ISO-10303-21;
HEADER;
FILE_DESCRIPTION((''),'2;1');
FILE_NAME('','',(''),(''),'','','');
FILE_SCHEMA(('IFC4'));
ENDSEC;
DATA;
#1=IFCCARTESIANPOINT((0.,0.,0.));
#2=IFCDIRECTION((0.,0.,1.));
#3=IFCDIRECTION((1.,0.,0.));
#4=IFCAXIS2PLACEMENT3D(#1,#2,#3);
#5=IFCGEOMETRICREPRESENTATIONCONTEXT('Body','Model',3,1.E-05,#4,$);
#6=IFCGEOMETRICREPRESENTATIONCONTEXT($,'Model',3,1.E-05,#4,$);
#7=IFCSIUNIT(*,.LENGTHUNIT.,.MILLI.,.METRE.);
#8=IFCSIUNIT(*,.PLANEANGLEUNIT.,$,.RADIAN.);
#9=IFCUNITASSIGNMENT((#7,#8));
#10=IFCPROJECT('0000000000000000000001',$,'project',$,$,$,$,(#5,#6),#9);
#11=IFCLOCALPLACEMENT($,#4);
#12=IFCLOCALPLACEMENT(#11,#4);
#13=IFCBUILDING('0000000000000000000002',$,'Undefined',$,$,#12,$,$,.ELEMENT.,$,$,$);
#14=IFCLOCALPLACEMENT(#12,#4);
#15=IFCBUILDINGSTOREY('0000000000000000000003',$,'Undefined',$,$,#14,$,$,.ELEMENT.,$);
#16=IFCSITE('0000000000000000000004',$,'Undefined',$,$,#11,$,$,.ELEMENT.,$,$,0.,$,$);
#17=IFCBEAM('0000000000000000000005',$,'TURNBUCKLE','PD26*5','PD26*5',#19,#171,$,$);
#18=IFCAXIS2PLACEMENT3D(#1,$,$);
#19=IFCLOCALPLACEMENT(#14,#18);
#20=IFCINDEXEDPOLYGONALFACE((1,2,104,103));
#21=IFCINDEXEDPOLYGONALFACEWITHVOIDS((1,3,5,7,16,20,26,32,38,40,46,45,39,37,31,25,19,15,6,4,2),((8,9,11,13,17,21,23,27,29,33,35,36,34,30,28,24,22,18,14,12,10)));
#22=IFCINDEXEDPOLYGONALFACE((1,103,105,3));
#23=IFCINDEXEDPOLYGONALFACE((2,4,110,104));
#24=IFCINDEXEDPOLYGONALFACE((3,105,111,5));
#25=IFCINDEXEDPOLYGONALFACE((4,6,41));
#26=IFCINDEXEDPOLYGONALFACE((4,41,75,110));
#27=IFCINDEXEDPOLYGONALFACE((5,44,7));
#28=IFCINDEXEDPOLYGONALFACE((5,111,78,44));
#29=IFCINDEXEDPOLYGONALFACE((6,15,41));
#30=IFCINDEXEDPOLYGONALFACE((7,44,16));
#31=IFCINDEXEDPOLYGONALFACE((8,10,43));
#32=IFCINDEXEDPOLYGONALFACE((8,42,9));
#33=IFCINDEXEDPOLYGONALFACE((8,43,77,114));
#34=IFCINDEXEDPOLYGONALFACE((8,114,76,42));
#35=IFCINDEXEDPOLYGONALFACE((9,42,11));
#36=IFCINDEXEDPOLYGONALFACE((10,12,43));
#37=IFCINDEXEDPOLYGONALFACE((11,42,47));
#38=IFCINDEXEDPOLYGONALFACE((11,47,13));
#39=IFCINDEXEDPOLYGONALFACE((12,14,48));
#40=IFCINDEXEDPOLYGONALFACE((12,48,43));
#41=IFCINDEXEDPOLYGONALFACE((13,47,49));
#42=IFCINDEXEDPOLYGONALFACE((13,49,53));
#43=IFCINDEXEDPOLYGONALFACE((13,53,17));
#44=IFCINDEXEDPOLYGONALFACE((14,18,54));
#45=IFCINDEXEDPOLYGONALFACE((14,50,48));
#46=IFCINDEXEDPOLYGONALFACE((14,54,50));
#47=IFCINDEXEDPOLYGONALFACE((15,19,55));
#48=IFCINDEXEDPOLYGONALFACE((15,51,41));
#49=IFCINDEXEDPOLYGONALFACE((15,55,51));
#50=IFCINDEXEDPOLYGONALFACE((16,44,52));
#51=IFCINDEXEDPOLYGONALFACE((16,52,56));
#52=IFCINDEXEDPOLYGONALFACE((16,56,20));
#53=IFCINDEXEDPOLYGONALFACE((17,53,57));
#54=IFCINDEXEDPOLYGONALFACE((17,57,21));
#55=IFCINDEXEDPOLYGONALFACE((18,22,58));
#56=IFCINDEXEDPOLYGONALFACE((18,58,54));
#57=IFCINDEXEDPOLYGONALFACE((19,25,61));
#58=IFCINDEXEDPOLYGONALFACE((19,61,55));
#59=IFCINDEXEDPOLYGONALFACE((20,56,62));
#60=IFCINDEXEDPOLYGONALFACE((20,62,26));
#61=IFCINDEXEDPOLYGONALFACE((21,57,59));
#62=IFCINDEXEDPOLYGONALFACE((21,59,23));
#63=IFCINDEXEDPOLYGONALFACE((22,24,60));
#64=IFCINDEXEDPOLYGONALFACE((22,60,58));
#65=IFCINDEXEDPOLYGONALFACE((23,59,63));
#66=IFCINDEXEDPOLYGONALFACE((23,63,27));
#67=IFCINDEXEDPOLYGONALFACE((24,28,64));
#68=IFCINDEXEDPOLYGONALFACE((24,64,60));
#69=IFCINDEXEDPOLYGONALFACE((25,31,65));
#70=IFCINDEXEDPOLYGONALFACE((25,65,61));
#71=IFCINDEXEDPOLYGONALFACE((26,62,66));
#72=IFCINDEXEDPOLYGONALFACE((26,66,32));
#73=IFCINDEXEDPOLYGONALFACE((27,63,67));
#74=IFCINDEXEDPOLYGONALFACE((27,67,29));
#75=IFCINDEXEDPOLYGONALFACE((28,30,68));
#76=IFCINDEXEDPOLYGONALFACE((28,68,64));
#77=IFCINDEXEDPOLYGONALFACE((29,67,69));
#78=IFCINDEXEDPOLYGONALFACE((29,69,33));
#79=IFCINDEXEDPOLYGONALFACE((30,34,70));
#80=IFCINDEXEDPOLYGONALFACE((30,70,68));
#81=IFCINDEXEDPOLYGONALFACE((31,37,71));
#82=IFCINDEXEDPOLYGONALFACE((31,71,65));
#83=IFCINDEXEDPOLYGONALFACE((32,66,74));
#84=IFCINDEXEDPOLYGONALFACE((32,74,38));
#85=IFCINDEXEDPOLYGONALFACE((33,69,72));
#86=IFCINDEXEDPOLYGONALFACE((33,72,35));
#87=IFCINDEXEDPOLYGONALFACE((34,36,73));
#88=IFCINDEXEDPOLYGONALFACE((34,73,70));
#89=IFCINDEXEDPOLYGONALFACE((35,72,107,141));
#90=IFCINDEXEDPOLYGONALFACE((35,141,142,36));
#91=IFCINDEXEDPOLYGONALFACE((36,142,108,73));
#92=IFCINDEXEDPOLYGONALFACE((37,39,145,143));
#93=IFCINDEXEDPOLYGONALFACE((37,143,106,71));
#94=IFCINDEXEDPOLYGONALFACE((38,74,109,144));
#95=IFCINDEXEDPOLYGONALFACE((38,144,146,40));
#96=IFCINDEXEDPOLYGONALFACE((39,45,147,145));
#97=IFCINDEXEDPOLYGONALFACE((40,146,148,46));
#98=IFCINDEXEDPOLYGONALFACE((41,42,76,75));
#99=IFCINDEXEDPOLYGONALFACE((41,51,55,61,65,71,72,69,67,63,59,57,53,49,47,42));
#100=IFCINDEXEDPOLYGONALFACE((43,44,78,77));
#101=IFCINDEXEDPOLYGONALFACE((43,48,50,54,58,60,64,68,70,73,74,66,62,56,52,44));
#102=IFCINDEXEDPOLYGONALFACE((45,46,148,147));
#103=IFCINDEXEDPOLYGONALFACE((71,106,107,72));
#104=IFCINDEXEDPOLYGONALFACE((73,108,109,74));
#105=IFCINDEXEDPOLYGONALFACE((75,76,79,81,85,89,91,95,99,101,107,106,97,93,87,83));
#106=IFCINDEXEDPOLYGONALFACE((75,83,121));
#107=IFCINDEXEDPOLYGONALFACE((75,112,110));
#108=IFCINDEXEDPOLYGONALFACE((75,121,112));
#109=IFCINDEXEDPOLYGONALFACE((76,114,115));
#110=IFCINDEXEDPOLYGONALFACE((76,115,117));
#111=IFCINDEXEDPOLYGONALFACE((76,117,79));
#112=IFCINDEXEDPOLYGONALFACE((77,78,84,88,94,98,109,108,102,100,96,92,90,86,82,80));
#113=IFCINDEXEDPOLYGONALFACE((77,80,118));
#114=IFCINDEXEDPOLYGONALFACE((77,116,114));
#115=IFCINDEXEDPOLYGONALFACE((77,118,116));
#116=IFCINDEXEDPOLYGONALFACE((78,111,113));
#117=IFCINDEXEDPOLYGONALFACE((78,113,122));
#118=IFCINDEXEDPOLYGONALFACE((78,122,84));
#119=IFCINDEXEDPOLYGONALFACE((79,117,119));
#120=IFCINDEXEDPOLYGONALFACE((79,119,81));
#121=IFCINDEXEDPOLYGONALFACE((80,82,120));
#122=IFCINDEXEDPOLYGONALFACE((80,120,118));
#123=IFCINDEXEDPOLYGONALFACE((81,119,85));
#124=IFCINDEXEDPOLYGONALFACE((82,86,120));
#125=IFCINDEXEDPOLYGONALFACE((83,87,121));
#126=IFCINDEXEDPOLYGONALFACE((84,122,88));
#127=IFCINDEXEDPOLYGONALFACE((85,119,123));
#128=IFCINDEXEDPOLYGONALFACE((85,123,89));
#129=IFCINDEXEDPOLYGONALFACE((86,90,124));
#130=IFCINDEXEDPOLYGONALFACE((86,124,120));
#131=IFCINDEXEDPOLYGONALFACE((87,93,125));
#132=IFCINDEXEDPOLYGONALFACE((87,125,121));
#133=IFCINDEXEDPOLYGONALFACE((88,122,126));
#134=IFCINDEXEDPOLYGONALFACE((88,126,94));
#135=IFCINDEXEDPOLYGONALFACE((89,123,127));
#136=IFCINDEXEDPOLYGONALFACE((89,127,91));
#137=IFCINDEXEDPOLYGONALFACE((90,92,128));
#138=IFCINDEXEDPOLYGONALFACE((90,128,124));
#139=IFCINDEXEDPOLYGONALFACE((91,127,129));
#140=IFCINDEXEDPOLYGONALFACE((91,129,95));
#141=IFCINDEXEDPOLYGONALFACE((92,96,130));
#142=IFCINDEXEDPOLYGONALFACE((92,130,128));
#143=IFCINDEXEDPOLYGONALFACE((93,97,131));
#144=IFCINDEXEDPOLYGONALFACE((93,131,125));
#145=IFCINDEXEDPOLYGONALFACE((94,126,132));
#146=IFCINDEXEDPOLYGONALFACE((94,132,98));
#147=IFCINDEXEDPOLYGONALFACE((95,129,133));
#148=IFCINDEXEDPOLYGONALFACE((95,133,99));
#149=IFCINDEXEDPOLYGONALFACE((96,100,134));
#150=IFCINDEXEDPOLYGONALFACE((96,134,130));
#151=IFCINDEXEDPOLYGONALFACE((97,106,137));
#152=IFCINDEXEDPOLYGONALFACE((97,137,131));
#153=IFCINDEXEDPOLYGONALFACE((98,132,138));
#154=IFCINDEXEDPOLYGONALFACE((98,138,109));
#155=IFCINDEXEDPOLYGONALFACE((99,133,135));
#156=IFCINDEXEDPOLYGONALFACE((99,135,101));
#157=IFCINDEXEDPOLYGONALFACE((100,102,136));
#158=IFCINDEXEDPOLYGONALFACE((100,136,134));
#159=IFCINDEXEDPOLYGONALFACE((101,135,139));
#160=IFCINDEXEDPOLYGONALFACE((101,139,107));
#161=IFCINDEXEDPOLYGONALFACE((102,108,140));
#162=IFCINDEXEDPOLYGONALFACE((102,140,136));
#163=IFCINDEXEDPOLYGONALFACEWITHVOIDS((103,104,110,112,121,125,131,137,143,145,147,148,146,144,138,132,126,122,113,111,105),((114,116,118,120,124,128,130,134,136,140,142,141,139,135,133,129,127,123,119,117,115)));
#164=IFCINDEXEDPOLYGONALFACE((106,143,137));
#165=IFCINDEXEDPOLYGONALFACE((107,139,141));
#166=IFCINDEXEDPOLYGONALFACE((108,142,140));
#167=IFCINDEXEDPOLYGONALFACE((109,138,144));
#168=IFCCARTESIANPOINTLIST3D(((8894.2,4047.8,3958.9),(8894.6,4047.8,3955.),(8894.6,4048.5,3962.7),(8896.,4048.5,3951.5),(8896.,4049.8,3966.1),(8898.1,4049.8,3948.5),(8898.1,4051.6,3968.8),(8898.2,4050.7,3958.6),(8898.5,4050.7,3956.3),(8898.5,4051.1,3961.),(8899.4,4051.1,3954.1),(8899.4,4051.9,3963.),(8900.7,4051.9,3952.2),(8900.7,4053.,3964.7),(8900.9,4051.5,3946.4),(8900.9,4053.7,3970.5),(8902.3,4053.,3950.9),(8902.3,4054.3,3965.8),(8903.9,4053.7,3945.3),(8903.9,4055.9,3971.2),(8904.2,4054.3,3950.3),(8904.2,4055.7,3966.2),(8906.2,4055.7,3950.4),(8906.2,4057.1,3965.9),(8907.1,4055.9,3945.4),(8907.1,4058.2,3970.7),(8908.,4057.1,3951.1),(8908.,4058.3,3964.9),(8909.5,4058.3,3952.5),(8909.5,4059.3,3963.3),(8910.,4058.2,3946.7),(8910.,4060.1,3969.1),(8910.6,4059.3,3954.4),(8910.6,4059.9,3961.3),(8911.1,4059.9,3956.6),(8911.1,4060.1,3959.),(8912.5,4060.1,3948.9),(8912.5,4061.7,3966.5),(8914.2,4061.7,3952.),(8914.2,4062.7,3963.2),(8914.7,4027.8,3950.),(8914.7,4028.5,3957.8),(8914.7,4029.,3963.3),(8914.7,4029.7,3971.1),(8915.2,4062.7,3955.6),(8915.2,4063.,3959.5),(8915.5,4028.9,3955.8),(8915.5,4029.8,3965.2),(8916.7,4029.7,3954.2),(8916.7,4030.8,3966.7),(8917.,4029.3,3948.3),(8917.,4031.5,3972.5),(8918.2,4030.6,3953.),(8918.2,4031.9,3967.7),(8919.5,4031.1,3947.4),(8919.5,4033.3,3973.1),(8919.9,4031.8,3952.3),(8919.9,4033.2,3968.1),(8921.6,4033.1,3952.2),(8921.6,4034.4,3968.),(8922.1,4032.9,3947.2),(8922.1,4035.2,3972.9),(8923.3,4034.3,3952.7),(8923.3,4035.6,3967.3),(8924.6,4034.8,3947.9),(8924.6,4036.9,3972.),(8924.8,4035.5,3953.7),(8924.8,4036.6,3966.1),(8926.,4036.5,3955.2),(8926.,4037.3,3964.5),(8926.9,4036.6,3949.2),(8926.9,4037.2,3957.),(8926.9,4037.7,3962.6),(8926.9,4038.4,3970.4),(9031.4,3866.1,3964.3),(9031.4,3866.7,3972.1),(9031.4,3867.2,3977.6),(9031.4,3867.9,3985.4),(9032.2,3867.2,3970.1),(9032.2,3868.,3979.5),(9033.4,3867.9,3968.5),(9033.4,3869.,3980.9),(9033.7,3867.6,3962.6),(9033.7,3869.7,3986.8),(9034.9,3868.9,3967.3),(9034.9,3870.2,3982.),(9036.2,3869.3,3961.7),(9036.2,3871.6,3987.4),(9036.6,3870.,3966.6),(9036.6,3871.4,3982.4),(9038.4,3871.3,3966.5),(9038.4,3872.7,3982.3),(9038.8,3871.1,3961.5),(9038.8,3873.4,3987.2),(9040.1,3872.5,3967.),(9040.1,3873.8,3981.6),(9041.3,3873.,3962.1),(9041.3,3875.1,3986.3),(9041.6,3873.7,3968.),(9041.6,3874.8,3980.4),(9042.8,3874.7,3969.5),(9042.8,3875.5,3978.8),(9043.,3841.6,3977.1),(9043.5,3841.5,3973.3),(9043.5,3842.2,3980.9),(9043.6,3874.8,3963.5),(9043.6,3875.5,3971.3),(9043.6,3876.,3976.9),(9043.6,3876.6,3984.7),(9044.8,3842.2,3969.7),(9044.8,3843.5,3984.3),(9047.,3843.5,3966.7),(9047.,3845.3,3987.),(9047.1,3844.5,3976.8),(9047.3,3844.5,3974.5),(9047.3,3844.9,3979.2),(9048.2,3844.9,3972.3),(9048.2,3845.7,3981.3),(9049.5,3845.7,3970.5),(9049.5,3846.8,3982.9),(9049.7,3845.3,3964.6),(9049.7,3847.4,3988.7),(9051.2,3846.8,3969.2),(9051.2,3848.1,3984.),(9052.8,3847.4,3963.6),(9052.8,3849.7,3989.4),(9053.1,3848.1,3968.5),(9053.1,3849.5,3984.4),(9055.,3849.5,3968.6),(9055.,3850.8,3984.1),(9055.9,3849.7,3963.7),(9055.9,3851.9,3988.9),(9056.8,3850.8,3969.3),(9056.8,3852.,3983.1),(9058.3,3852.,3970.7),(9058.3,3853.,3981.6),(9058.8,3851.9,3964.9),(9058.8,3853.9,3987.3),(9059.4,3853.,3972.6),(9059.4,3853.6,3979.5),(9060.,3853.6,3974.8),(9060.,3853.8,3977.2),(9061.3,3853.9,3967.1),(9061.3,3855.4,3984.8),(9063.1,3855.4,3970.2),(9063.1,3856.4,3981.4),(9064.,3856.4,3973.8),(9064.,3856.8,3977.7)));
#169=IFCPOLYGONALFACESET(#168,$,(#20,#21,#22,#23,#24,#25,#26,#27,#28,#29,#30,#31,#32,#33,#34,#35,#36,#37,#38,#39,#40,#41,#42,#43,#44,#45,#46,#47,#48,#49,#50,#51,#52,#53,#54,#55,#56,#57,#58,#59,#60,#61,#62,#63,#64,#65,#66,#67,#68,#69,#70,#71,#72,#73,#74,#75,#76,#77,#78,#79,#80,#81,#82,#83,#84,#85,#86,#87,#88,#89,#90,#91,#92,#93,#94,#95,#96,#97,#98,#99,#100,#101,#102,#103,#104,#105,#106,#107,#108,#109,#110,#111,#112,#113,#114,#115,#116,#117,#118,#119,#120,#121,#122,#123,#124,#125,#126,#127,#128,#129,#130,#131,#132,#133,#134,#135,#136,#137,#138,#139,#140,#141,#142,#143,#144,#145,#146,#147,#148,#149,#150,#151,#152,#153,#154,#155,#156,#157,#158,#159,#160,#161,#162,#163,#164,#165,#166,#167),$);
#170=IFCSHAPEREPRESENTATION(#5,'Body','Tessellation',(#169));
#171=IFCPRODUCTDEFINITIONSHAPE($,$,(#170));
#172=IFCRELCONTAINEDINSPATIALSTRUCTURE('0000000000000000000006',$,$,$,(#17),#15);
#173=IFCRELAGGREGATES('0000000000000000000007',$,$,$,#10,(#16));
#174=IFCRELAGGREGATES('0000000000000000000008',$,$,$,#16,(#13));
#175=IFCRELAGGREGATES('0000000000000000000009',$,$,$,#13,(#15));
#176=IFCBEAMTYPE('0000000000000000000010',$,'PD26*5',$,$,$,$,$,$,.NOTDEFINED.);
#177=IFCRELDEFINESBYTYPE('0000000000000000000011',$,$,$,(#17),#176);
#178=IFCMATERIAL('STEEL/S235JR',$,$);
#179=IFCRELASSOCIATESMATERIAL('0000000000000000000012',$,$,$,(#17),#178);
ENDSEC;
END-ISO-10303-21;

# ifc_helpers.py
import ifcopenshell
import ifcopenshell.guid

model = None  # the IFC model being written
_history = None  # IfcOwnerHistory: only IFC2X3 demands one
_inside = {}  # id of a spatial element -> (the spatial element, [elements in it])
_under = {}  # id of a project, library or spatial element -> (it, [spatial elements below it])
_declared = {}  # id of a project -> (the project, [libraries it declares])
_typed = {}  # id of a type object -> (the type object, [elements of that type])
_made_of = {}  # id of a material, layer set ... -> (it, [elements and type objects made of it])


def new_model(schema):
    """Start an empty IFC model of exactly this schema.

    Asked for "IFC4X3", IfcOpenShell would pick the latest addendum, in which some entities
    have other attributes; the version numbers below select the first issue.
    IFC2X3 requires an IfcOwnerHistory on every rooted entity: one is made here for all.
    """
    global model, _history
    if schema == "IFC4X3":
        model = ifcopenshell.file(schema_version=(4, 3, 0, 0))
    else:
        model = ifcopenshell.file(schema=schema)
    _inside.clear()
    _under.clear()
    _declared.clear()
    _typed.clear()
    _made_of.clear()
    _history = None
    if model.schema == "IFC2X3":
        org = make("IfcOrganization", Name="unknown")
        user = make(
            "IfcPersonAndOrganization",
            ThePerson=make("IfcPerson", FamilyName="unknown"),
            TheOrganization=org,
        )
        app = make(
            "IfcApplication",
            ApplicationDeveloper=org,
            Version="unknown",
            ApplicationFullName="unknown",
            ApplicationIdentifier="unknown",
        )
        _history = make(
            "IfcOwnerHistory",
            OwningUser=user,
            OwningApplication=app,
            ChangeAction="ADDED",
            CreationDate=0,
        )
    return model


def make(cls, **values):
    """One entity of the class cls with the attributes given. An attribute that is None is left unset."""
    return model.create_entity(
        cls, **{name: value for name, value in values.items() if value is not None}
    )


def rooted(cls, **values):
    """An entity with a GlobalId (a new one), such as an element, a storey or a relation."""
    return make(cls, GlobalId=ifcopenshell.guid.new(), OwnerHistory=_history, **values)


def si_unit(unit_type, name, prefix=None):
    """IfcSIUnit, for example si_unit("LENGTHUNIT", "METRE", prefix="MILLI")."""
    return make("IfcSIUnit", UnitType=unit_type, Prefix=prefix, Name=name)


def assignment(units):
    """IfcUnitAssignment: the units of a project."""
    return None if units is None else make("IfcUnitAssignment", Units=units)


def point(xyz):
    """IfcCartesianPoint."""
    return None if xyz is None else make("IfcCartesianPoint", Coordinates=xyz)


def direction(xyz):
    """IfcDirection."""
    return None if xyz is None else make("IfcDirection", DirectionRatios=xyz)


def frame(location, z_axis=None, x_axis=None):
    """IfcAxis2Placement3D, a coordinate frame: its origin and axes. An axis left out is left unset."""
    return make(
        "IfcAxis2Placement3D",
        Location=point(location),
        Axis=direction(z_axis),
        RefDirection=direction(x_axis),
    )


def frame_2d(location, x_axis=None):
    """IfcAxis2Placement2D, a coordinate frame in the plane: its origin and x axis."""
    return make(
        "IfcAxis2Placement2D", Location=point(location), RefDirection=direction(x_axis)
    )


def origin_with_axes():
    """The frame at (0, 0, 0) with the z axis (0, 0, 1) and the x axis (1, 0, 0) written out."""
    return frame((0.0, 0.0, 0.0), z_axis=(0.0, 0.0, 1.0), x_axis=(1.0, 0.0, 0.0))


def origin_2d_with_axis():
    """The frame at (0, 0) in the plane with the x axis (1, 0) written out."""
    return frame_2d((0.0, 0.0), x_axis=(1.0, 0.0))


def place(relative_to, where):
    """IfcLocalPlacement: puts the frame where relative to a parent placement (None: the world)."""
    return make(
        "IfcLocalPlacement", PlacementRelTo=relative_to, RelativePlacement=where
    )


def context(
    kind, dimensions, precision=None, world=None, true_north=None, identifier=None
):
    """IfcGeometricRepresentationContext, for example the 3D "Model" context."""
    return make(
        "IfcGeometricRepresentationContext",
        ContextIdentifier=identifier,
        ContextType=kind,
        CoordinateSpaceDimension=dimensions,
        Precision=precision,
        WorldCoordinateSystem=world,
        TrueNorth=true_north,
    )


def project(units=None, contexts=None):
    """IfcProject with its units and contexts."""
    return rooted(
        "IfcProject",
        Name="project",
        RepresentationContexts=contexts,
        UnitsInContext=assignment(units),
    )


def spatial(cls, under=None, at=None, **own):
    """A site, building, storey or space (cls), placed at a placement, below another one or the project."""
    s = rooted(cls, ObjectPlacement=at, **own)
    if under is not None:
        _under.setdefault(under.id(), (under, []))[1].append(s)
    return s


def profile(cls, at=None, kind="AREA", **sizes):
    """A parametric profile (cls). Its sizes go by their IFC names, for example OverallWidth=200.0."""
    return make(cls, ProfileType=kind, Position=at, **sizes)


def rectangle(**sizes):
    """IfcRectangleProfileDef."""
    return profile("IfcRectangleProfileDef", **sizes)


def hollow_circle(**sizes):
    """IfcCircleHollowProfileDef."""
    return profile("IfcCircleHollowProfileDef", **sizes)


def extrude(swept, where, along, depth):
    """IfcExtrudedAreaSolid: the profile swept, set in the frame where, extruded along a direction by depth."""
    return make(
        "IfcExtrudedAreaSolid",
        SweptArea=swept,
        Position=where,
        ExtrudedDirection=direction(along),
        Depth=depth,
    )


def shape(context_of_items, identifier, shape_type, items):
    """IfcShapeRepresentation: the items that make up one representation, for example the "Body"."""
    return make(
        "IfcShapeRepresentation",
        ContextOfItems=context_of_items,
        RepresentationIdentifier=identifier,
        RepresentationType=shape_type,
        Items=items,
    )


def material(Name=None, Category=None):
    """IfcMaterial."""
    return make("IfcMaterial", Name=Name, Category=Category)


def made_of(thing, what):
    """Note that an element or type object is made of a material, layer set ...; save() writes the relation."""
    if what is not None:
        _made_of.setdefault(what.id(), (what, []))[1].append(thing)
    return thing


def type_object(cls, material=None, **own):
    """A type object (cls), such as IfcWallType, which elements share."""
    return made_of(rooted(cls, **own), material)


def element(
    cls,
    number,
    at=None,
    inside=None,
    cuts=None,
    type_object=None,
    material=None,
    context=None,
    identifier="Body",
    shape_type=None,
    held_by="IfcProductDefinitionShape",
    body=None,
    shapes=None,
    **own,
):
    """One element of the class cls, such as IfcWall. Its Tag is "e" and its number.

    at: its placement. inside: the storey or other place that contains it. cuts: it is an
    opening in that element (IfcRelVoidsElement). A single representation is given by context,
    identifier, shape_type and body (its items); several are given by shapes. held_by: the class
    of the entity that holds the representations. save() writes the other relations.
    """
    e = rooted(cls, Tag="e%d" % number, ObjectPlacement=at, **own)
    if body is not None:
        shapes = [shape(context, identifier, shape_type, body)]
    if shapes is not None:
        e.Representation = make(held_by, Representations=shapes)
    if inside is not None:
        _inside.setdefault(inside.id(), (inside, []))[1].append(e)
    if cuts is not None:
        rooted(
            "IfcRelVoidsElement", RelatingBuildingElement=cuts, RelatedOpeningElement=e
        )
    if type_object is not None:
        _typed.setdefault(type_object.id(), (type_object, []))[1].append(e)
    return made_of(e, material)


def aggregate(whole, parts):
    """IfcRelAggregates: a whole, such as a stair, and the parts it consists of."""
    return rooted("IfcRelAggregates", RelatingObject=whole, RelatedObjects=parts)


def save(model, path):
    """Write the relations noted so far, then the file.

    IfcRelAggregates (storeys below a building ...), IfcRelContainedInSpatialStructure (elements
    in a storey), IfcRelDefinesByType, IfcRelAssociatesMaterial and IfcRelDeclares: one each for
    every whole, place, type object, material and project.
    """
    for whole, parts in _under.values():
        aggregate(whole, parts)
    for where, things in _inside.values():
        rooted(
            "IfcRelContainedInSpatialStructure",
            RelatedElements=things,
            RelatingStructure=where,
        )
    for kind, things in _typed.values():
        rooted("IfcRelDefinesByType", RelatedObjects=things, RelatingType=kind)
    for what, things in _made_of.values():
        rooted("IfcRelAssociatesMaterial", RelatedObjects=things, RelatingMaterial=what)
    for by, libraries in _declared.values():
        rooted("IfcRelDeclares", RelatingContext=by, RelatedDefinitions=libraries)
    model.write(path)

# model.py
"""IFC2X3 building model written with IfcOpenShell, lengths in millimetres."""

from ifc_helpers import new_model, si_unit, frame, origin_with_axes, origin_2d_with_axis, place, context, project, spatial, rectangle, hollow_circle, extrude, material, type_object, element, save


model = new_model("IFC2X3")

# Units and contexts
model_context_1 = context("Model", 3, precision=1e-05, world=origin_with_axes(), identifier="Body")
model_context_2 = context("Model", 3, precision=1e-05, world=origin_with_axes())
ifc_project = project(units=[si_unit("LENGTHUNIT", "METRE", prefix="MILLI"), si_unit("PLANEANGLEUNIT", "RADIAN")], contexts=[model_context_1, model_context_2])

# Site, building, storey
site_placement = place(None, origin_with_axes())
site = spatial("IfcSite", under=ifc_project, at=site_placement, Name="Undefined", CompositionType="ELEMENT", RefElevation=0.0)
building_placement = place(site_placement, origin_with_axes())
building = spatial("IfcBuilding", under=site, at=building_placement, Name="Undefined", CompositionType="ELEMENT")
storey_placement = place(building_placement, origin_with_axes())
storey = spatial("IfcBuildingStorey", under=building, at=storey_placement, Name="Undefined", CompositionType="ELEMENT")

# Shared definitions
ifc_material = material(Name="STEEL/S235JR")

# Beam, opening
beam_type_1 = type_object("IfcBeamType", Name="PD26*5", PredefinedType="NOTDEFINED")
beam_1_placement = place(storey_placement, frame((8904.7, 4055.4, 3958.2), z_axis=(0.0, 0.087999, 0.996121), x_axis=(0.583639, -0.808863, 0.071457)))
beam_1 = element("IfcBeam", 1, at=beam_1_placement, inside=storey, type_object=beam_type_1, material=ifc_material, Name="TURNBUCKLE", Description="PD26*5", ObjectType="PD26*5", context=model_context_1, shape_type="SweptSolid", body=[
    extrude(hollow_circle(Radius=13.0, WallThickness=5.0, at=origin_2d_with_axis()), frame((255.0, 0.0, 0.0), z_axis=(-1.0, 0.0, 0.0), x_axis=(0.0, -1.0, 0.0)), (0.0, 0.0, 1.0), 255.0),
])
opening_1_placement = place(storey_placement, frame((8904.7, 4055.4, 3958.2), z_axis=(0.0, 0.087999, 0.996121), x_axis=(0.583639, -0.808863, 0.071457)))
element("IfcOpeningElement", 2, at=opening_1_placement, cuts=beam_1, ObjectType="Recess", context=model_context_1, shape_type="SweptSolid", body=[
    extrude(rectangle(XDim=15.0, YDim=52.0, at=origin_2d_with_axis()), frame((227.5, 0.0, 0.0), z_axis=(-1.0, 0.0, 0.0), x_axis=(0.0, -1.0, 0.0)), (0.0, 0.0, 1.0), 200.0),
])

save(model, "model.ifc")
